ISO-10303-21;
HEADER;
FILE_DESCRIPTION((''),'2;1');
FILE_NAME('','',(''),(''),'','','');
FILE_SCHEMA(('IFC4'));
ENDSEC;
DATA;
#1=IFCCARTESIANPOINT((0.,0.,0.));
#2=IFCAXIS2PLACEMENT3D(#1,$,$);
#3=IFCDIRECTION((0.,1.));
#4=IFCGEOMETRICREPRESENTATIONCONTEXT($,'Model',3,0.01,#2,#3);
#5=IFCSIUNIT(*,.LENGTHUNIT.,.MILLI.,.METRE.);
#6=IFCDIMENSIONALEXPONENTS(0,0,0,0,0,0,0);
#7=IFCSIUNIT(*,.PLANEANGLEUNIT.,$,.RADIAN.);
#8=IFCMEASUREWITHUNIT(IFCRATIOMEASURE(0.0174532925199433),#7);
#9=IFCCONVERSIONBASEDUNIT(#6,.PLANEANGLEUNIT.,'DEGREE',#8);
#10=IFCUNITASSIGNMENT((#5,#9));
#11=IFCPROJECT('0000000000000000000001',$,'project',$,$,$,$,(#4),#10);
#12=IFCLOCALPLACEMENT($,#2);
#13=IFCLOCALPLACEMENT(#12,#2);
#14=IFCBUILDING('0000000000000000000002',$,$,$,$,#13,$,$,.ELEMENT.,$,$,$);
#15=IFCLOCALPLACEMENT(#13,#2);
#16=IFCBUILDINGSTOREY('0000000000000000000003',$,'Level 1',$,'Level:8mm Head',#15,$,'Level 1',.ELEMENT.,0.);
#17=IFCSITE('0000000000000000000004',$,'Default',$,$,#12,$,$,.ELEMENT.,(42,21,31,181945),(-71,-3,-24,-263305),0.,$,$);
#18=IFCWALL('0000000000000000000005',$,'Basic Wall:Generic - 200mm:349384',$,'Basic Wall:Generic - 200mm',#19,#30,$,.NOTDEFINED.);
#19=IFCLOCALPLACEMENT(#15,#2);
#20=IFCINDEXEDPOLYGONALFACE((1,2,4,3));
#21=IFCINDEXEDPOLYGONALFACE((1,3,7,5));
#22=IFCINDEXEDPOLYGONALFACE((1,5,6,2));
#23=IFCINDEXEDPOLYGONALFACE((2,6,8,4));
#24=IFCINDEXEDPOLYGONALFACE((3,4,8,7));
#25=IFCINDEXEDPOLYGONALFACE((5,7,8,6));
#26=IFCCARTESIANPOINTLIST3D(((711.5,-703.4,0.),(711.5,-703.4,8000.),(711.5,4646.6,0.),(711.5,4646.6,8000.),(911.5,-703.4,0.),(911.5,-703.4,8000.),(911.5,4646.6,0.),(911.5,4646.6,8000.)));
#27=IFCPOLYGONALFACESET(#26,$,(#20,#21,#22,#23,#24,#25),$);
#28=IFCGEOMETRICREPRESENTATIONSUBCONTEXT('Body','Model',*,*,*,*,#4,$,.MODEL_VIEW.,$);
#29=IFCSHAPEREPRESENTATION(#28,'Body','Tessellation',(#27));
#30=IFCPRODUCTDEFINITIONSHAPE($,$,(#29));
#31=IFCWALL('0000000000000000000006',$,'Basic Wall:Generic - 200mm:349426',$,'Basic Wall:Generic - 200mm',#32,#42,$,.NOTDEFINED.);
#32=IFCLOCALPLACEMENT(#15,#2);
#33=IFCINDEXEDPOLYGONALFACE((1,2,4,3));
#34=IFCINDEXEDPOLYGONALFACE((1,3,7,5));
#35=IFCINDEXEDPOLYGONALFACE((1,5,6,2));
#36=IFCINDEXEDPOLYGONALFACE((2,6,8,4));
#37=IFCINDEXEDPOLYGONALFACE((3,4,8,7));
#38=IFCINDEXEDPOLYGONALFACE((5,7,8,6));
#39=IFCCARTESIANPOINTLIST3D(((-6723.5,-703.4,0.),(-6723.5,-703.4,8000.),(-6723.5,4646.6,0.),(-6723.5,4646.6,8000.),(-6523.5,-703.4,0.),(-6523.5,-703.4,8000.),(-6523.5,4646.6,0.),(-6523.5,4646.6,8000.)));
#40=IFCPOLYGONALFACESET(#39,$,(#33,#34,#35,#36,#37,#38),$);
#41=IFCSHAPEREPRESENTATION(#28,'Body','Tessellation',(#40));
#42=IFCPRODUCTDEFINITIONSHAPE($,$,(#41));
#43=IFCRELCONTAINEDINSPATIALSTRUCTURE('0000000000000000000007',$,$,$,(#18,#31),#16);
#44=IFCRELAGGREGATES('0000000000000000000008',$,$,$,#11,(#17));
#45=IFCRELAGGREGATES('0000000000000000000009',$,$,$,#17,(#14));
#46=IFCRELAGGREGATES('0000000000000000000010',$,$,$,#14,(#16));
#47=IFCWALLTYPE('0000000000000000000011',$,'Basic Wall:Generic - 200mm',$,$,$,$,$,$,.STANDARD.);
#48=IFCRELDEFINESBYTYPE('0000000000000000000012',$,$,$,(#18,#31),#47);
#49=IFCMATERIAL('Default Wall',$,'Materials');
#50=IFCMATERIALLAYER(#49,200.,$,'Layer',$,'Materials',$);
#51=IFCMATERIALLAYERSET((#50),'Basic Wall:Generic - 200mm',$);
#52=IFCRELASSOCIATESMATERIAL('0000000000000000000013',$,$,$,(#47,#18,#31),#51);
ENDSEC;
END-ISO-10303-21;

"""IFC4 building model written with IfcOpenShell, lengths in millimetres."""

from ifc_helpers import new_model, entity, si_unit, converted_unit, direction, frame, frame_2d, origin, place, context, subcontext, project, spatial, rectangle, extrude, material, layer, layer_set, layer_usage, type_object, element, save


model = new_model("IFC4")

# Units and contexts
model_context = context("Model", 3, precision=0.01, world=origin(), true_north=direction((0.0, 1.0)))
body_context = subcontext(model_context, "Body", "Model", "MODEL_VIEW")
ifc_project = project(units=[si_unit("LENGTHUNIT", "METRE", prefix="MILLI"), converted_unit("PLANEANGLEUNIT", "DEGREE", entity("IfcRatioMeasure", 0.0174532925199433), si_unit("PLANEANGLEUNIT", "RADIAN"), dimensions=[0, 0, 0, 0, 0, 0, 0])], contexts=[model_context])

# Site, building, storey
site_placement = place(None, origin())
site = spatial("IfcSite", under=ifc_project, at=site_placement, Name="Default", CompositionType="ELEMENT", RefLatitude=(42, 21, 31, 181945), RefLongitude=(-71, -3, -24, -263305), RefElevation=0.0)
building_placement = place(site_placement, origin())
building = spatial("IfcBuilding", under=site, at=building_placement, CompositionType="ELEMENT")
storey_placement = place(building_placement, origin())
storey = spatial("IfcBuildingStorey", under=building, at=storey_placement, Name="Level 1", ObjectType="Level:8mm Head", LongName="Level 1", CompositionType="ELEMENT", Elevation=0.0)

# Shared definitions
ifc_material_1 = material(Name="Default Wall", Category="Materials")
ifc_layer = layer(ifc_material_1, 200.0, Name="Layer", Category="Materials")
ifc_layer_set = layer_set([ifc_layer], Name="Basic Wall:Generic - 200mm")
wall_type = type_object("IfcWallType", Name="Basic Wall:Generic - 200mm", PredefinedType="STANDARD", material=ifc_layer_set)

# Walls
ifc_layer_usage_1 = layer_usage(ifc_layer_set, "AXIS2", "NEGATIVE", 100.0)
wall_1_placement = place(storey_placement, frame((811.5, 4646.6, 0.0), z_axis=(0.0, 0.0, 1.0), x_axis=(0.0, -1.0, 0.0)))
element("IfcWall", 1, at=wall_1_placement, inside=storey, type_object=wall_type, material=ifc_layer_usage_1, Name="Basic Wall:Generic - 200mm:349384", ObjectType="Basic Wall:Generic - 200mm", PredefinedType="NOTDEFINED", context=body_context, shape_type="SweptSolid", body=[
    extrude(rectangle(XDim=5350.0, YDim=200.0, at=frame_2d((2675.0, 0.0), x_axis=(-1.0, 0.0))), origin(), (0.0, 0.0, 1.0), 8000.0),
])
ifc_layer_usage_2 = layer_usage(ifc_layer_set, "AXIS2", "NEGATIVE", 100.0)
wall_2_placement = place(storey_placement, frame((-6623.5, 4646.6, 0.0), z_axis=(0.0, 0.0, 1.0), x_axis=(0.0, -1.0, 0.0)))
element("IfcWall", 2, at=wall_2_placement, inside=storey, type_object=wall_type, material=ifc_layer_usage_2, Name="Basic Wall:Generic - 200mm:349426", ObjectType="Basic Wall:Generic - 200mm", PredefinedType="NOTDEFINED", context=body_context, shape_type="SweptSolid", body=[
    extrude(rectangle(XDim=5350.0, YDim=200.0, at=frame_2d((2675.0, 0.0), x_axis=(-1.0, 0.0))), origin(), (0.0, 0.0, 1.0), 8000.0),
])

save(model, "model.ifc")
